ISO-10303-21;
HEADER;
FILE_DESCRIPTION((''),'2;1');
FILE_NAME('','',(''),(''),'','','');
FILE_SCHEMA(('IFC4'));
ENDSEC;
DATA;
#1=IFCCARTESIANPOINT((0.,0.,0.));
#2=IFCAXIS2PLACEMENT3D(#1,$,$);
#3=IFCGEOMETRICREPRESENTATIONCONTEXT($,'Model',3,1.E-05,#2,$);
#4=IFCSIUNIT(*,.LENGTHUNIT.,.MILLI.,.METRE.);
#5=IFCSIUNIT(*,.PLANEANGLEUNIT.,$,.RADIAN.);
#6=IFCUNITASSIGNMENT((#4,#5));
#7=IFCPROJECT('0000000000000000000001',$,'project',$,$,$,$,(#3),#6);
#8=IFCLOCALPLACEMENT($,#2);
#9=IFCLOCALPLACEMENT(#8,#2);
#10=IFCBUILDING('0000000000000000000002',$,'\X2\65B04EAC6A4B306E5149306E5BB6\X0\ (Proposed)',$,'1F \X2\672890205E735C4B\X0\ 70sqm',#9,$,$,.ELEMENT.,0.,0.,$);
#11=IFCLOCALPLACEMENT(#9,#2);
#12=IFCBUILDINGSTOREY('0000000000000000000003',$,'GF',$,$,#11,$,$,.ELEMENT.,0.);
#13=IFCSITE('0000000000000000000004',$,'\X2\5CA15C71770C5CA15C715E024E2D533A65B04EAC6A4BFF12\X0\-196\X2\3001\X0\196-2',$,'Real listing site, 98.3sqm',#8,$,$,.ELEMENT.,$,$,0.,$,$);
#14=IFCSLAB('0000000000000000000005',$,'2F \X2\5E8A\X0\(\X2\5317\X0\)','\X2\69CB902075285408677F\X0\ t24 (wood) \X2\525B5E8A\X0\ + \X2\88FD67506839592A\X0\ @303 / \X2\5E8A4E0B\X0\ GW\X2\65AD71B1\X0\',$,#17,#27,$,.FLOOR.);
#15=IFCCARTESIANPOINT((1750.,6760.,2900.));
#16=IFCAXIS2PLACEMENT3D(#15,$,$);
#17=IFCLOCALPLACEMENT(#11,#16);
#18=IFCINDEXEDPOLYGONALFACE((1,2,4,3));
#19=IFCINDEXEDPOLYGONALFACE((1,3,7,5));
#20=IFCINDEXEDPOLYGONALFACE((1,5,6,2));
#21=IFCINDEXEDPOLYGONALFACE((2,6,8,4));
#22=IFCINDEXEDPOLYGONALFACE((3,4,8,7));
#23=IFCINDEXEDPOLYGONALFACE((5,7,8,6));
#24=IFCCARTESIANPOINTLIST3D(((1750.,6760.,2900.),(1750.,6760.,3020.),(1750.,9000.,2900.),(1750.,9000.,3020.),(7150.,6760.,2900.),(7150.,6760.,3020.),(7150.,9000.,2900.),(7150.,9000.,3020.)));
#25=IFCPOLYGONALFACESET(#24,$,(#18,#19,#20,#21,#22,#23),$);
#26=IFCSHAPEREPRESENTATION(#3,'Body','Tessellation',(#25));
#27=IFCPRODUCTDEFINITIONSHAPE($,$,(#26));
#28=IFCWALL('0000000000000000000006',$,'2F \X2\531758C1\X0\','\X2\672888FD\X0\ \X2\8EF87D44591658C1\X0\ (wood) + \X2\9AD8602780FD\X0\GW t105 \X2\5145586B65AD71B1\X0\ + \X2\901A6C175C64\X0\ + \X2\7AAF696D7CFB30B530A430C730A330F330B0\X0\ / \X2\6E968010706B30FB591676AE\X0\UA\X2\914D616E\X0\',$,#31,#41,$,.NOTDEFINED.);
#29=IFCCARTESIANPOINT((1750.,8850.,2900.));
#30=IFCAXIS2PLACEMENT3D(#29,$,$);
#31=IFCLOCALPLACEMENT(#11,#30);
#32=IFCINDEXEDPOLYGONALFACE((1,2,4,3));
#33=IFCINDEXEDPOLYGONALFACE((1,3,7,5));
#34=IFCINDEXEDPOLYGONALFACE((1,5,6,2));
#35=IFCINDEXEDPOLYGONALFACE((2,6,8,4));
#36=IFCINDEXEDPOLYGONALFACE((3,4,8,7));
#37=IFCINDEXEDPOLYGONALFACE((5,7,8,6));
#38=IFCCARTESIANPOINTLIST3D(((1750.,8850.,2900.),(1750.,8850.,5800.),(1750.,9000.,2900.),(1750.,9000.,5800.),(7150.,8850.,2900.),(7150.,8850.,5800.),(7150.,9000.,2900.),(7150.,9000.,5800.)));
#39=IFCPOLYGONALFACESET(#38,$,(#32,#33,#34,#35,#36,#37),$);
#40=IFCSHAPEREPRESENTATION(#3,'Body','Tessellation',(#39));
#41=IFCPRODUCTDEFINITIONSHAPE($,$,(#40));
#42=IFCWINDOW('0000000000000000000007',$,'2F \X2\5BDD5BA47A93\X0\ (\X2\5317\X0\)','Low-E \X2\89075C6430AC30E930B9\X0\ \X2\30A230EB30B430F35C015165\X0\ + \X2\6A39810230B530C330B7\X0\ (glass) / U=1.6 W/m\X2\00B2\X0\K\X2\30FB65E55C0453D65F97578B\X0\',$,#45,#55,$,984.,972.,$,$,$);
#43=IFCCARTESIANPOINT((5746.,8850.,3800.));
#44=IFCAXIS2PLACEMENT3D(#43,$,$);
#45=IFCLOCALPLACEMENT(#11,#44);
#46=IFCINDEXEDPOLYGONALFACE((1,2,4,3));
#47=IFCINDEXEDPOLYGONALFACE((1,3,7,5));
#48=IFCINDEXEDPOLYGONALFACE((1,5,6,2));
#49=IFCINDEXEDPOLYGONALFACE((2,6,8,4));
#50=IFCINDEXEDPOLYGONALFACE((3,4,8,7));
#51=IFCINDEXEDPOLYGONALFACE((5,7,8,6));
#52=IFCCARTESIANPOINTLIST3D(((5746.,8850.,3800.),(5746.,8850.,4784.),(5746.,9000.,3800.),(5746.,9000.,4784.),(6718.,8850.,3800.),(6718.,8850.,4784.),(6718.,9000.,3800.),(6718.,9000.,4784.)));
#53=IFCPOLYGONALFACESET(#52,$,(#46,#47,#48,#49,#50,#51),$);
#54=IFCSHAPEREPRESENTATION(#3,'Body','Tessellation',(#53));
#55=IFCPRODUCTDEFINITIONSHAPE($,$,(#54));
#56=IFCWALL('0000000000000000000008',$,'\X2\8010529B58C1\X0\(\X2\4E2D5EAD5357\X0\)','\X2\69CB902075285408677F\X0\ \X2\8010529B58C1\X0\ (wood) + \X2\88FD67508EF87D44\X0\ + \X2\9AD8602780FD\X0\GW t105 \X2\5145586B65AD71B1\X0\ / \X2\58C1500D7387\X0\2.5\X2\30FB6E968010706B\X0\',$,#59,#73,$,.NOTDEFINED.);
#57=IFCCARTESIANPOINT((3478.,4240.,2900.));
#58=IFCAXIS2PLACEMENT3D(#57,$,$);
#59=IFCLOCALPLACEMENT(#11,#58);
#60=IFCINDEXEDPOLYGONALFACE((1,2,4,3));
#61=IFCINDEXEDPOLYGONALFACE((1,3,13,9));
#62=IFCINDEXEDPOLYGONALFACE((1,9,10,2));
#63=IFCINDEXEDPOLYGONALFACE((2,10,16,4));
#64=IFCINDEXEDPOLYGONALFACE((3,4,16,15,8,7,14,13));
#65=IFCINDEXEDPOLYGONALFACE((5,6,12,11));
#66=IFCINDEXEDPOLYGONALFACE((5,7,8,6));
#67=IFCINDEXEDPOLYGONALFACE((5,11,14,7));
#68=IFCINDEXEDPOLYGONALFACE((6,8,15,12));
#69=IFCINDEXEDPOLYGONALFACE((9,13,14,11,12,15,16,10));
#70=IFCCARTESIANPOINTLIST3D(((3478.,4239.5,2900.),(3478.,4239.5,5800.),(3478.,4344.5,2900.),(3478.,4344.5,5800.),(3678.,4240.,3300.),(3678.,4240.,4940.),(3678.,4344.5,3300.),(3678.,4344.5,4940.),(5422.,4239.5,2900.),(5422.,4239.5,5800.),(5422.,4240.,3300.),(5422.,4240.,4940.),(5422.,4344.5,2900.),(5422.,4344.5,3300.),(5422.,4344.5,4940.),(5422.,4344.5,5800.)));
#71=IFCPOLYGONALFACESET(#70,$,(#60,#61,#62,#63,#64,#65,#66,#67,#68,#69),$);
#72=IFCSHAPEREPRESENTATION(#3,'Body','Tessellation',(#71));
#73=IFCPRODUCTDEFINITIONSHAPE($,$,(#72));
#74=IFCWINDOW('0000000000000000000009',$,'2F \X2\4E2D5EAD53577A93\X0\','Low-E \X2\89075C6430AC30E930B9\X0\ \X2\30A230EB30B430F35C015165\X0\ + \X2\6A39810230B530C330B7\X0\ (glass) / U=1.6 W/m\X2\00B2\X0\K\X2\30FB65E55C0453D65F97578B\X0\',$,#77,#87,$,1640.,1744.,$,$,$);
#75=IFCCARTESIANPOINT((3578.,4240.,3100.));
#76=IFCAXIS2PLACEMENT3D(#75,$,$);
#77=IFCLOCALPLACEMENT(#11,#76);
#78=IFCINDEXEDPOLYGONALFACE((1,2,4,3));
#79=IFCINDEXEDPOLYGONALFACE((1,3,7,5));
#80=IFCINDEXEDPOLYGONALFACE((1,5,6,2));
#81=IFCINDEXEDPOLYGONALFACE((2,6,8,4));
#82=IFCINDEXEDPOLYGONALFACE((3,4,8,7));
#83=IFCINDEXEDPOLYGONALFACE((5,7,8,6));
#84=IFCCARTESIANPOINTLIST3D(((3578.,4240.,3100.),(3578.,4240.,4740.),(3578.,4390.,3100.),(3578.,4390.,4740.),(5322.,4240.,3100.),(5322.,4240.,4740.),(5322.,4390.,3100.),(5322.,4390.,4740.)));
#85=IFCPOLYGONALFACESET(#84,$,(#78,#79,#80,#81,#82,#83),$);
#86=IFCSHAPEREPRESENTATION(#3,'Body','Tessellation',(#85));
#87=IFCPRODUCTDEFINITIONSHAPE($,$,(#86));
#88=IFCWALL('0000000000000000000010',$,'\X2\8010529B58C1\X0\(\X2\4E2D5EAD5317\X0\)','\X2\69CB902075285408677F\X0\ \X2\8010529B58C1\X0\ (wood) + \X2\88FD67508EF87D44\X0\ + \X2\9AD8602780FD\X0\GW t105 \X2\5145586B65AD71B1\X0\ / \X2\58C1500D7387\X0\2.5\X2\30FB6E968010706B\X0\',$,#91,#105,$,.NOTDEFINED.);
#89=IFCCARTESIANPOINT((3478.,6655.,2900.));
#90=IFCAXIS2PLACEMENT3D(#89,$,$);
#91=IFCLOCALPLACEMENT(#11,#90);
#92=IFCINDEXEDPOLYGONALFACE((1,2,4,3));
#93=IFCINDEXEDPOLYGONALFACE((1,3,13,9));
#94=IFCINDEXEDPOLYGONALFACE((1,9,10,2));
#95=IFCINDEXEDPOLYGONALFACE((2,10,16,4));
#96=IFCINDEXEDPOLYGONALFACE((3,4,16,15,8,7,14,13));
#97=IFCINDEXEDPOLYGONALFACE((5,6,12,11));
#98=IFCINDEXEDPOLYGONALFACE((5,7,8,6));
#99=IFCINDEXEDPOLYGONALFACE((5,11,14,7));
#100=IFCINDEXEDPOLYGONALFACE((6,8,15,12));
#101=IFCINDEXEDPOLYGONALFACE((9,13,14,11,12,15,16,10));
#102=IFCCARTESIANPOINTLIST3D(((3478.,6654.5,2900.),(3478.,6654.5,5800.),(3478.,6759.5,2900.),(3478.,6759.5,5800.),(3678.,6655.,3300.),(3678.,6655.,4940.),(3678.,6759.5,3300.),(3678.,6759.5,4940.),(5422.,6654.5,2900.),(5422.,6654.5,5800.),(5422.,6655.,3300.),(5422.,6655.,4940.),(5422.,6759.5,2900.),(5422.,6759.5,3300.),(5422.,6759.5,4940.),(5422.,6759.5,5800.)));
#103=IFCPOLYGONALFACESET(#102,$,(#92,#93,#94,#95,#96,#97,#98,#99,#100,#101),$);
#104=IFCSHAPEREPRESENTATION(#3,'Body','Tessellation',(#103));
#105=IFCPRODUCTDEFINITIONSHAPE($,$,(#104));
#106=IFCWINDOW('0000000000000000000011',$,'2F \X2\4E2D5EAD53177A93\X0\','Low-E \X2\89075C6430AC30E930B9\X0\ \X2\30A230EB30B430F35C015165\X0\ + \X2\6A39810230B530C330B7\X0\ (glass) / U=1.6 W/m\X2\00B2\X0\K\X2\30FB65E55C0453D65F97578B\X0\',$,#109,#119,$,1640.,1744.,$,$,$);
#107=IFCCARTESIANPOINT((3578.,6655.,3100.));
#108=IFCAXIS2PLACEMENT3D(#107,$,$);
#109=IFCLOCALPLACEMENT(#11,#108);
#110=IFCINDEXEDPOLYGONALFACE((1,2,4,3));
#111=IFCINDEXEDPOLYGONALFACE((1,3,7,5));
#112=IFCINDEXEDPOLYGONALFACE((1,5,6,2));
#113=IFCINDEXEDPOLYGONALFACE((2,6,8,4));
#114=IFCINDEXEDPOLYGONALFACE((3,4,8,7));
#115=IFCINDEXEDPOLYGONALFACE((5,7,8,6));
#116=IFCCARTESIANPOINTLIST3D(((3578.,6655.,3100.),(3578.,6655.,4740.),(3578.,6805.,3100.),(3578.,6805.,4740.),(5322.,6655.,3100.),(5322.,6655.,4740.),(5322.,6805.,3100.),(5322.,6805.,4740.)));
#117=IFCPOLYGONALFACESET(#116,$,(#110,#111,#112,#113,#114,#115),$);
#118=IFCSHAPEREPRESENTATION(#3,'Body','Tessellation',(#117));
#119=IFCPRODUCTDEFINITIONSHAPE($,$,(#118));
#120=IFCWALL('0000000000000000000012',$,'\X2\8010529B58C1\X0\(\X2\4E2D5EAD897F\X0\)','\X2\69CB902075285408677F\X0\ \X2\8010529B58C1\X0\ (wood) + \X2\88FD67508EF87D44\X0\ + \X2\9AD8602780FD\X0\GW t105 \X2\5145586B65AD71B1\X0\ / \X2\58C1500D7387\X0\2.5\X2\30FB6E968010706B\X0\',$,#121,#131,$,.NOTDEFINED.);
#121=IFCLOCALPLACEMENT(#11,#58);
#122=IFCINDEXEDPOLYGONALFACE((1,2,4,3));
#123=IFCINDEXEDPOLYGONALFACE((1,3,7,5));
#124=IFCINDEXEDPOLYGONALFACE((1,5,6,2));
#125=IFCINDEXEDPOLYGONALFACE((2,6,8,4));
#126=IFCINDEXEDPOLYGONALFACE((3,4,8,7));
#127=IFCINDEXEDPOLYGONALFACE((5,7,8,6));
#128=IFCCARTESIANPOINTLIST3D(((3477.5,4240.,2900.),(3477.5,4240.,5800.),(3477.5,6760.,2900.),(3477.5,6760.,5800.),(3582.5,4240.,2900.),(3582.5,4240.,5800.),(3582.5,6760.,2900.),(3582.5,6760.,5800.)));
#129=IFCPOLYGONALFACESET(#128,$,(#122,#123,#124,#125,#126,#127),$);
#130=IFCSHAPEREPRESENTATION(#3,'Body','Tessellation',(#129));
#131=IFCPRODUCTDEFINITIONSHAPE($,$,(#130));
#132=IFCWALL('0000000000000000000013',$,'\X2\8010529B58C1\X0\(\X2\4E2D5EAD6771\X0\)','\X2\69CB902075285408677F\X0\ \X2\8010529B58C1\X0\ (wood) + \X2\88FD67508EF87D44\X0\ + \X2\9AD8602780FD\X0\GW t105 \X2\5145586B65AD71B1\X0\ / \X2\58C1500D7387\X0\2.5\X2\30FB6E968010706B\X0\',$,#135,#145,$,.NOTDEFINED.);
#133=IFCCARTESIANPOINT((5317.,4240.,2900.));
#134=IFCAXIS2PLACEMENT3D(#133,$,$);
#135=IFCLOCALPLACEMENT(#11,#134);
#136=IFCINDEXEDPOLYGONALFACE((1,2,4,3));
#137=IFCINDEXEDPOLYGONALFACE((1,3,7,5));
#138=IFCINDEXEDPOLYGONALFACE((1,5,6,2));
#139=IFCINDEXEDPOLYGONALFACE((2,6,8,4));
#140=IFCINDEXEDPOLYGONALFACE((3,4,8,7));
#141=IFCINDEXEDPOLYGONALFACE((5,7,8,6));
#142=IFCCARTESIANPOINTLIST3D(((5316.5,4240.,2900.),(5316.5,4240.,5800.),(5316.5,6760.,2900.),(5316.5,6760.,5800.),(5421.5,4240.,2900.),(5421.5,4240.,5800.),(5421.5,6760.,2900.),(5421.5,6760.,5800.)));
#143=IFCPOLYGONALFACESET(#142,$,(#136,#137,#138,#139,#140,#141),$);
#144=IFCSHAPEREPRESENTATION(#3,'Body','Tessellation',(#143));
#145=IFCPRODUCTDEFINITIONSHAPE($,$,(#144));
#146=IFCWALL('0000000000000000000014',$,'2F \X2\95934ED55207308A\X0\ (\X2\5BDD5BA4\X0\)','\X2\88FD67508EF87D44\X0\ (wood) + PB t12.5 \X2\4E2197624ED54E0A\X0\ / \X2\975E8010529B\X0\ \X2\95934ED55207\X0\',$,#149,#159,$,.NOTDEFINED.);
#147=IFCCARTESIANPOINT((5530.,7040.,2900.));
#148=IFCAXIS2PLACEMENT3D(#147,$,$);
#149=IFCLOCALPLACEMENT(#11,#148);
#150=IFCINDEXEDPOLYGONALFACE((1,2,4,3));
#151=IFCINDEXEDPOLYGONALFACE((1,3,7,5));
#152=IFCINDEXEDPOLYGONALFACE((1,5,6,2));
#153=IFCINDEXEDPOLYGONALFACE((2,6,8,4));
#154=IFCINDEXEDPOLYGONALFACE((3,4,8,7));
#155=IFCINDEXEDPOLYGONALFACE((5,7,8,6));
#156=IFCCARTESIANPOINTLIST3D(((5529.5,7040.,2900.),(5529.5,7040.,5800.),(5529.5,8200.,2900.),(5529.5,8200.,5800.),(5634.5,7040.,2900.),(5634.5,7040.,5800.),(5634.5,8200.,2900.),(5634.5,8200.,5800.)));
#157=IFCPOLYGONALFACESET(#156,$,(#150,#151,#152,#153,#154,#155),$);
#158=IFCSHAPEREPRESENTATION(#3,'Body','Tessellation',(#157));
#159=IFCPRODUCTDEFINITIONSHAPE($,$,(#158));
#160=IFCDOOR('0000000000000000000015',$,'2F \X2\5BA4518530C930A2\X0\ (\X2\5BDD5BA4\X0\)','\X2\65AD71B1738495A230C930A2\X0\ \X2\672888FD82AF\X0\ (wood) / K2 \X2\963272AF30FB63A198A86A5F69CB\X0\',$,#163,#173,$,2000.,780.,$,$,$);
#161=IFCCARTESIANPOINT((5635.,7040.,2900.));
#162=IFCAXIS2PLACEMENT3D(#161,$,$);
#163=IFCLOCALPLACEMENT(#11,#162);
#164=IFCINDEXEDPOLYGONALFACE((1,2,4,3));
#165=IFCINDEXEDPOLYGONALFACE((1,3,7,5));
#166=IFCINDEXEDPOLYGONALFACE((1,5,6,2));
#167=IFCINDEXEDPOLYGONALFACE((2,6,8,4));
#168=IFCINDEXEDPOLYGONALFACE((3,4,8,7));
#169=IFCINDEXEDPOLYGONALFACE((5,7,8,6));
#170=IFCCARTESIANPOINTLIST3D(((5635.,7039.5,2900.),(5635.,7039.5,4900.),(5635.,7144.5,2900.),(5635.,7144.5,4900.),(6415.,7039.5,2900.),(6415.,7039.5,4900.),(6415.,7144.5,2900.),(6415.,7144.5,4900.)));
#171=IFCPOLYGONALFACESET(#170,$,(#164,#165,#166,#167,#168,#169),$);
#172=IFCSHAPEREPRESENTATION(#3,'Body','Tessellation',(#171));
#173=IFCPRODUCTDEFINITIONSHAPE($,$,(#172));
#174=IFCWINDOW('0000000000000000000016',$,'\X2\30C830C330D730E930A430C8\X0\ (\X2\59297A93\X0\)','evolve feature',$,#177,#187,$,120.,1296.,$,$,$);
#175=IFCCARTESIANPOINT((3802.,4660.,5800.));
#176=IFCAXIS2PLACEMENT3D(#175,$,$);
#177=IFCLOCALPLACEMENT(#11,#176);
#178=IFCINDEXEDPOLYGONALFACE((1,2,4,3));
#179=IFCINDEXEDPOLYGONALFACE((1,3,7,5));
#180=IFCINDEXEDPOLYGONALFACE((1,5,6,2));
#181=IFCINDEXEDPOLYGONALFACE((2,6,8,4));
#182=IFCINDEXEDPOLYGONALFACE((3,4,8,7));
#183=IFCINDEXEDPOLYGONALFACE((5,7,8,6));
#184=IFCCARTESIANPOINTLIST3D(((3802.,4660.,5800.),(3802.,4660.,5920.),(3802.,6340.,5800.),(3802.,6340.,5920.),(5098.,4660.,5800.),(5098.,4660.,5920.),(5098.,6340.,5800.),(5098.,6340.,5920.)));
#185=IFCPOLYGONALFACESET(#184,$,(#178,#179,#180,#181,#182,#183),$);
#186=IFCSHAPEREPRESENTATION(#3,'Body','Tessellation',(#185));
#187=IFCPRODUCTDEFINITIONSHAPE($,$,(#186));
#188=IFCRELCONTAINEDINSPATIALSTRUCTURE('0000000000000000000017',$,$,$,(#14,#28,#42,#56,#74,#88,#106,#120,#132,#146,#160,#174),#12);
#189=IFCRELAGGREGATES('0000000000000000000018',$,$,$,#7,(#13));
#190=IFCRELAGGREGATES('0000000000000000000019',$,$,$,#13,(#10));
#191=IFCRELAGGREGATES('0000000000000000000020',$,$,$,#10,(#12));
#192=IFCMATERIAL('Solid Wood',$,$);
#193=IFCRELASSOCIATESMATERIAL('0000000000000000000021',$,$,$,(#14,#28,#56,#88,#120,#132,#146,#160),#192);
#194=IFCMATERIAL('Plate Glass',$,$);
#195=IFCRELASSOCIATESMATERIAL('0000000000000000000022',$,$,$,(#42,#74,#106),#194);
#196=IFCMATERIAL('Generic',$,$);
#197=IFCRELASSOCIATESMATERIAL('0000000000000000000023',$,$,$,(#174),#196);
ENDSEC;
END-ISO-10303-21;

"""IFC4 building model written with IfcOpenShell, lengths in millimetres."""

from ifc_helpers import new_model, si_unit, frame, frame_2d, origin, place, context, project, spatial, rectangle, extrude, material, element, fill, save


model = new_model("IFC4")

# Units and contexts
model_context = context("Model", 3, precision=1e-05, world=origin())
ifc_project = project(units=[si_unit("LENGTHUNIT", "METRE", prefix="MILLI"), si_unit("PLANEANGLEUNIT", "RADIAN")], contexts=[model_context])

# Site, building, storey
site_placement = place(None, origin())
site = spatial("IfcSite", under=ifc_project, at=site_placement, Name="岡山県岡山市中区新京橋２-196、196-2", ObjectType="Real listing site, 98.3sqm", CompositionType="ELEMENT", RefElevation=0.0)
building_placement = place(site_placement, origin())
building = spatial("IfcBuilding", under=site, at=building_placement, Name="新京橋の光の家 (Proposed)", ObjectType="1F 木造平屋 70sqm", CompositionType="ELEMENT", ElevationOfRefHeight=0.0, ElevationOfTerrain=0.0)
storey_placement = place(building_placement, origin())
storey = spatial("IfcBuildingStorey", under=building, at=storey_placement, Name="GF", CompositionType="ELEMENT", Elevation=0.0)

# Slab
ifc_material_1 = material(Name="Solid Wood")
slab_placement = place(storey_placement, frame((1750.0, 6760.0, 2900.0)))
element("IfcSlab", 1, at=slab_placement, inside=storey, material=ifc_material_1, Name="2F 床(北)", Description="構造用合板 t24 (wood) 剛床 + 製材根太 @303 / 床下 GW断熱", PredefinedType="FLOOR", context=model_context, shape_type="SweptSolid", body=[
    extrude(rectangle(XDim=5400.0, YDim=2240.0, at=frame_2d((2700.0, 1120.0))), frame((1750.0, 6760.0, 2900.0)), (0.0, 0.0, 1.0), 120.0),
])

# Walls, openings, windows
wall_1_placement = place(storey_placement, frame((1750.0, 8850.0, 2900.0)))
wall_1 = element("IfcWall", 2, at=wall_1_placement, inside=storey, material=ifc_material_1, Name="2F 北壁", Description="木製 軸組外壁 (wood) + 高性能GW t105 充填断熱 + 通気層 + 窯業系サイディング / 準耐火・外皮UA配慮", PredefinedType="NOTDEFINED", context=model_context, shape_type="SweptSolid", body=[
    extrude(rectangle(XDim=5400.0, YDim=150.0, at=frame_2d((2700.0, 75.0))), frame((1750.0, 8850.0, 2900.0)), (0.0, 0.0, 1.0), 2900.0),
])
opening_1_placement = place(storey_placement, frame((5746.0, 8850.0, 3800.0)))
opening_1 = element("IfcOpeningElement", 3, at=opening_1_placement, cuts=wall_1, PredefinedType="NOTDEFINED", context=model_context, shape_type="SweptSolid", body=[
    extrude(rectangle(XDim=972.0, YDim=150.0, at=frame_2d((486.0, 75.0))), frame((5746.0, 8850.0, 3800.0)), (0.0, 0.0, 1.0), 984.0),
])
ifc_material_2 = material(Name="Plate Glass")
window_1_placement = place(storey_placement, frame((5746.0, 8850.0, 3800.0)))
window_1 = element("IfcWindow", 4, at=window_1_placement, inside=storey, material=ifc_material_2, Name="2F 寝室窓 (北)", Description="Low-E 複層ガラス アルゴン封入 + 樹脂サッシ (glass) / U=1.6 W/m²K・日射取得型", OverallHeight=984.0, OverallWidth=972.0, context=model_context, shape_type="SweptSolid", body=[
    extrude(rectangle(XDim=972.0, YDim=150.0, at=frame_2d((486.0, 75.0))), frame((5746.0, 8850.0, 3800.0)), (0.0, 0.0, 1.0), 984.0),
])
fill(opening_1, window_1)
wall_2_placement = place(storey_placement, frame((3478.0, 4240.0, 2900.0)))
wall_2 = element("IfcWall", 5, at=wall_2_placement, inside=storey, material=ifc_material_1, Name="耐力壁(中庭南)", Description="構造用合板 耐力壁 (wood) + 製材軸組 + 高性能GW t105 充填断熱 / 壁倍率2.5・準耐火", PredefinedType="NOTDEFINED", context=model_context, shape_type="SweptSolid", body=[
    extrude(rectangle(XDim=1944.0, YDim=105.0, at=frame_2d((972.0, 52.0))), frame((3478.0, 4240.0, 2900.0)), (0.0, 0.0, 1.0), 2900.0),
])
opening_2_placement = place(storey_placement, frame((3578.0, 4240.0, 3100.0)))
opening_2 = element("IfcOpeningElement", 6, at=opening_2_placement, cuts=wall_2, PredefinedType="NOTDEFINED", context=model_context, shape_type="SweptSolid", body=[
    extrude(rectangle(XDim=1744.0, YDim=150.0, at=frame_2d((872.0, 75.0))), frame((3578.0, 4240.0, 3100.0)), (0.0, 0.0, 1.0), 1640.0),
])
window_2_placement = place(storey_placement, frame((3578.0, 4240.0, 3100.0)))
window_2 = element("IfcWindow", 7, at=window_2_placement, inside=storey, material=ifc_material_2, Name="2F 中庭南窓", Description="Low-E 複層ガラス アルゴン封入 + 樹脂サッシ (glass) / U=1.6 W/m²K・日射取得型", OverallHeight=1640.0, OverallWidth=1744.0, context=model_context, shape_type="SweptSolid", body=[
    extrude(rectangle(XDim=1744.0, YDim=150.0, at=frame_2d((872.0, 75.0))), frame((3578.0, 4240.0, 3100.0)), (0.0, 0.0, 1.0), 1640.0),
])
fill(opening_2, window_2)
wall_3_placement = place(storey_placement, frame((3478.0, 6655.0, 2900.0)))
wall_3 = element("IfcWall", 8, at=wall_3_placement, inside=storey, material=ifc_material_1, Name="耐力壁(中庭北)", Description="構造用合板 耐力壁 (wood) + 製材軸組 + 高性能GW t105 充填断熱 / 壁倍率2.5・準耐火", PredefinedType="NOTDEFINED", context=model_context, shape_type="SweptSolid", body=[
    extrude(rectangle(XDim=1944.0, YDim=105.0, at=frame_2d((972.0, 52.0))), frame((3478.0, 6655.0, 2900.0)), (0.0, 0.0, 1.0), 2900.0),
])
opening_3_placement = place(storey_placement, frame((3578.0, 6655.0, 3100.0)))
opening_3 = element("IfcOpeningElement", 9, at=opening_3_placement, cuts=wall_3, PredefinedType="NOTDEFINED", context=model_context, shape_type="SweptSolid", body=[
    extrude(rectangle(XDim=1744.0, YDim=150.0, at=frame_2d((872.0, 75.0))), frame((3578.0, 6655.0, 3100.0)), (0.0, 0.0, 1.0), 1640.0),
])
window_3_placement = place(storey_placement, frame((3578.0, 6655.0, 3100.0)))
window_3 = element("IfcWindow", 10, at=window_3_placement, inside=storey, material=ifc_material_2, Name="2F 中庭北窓", Description="Low-E 複層ガラス アルゴン封入 + 樹脂サッシ (glass) / U=1.6 W/m²K・日射取得型", OverallHeight=1640.0, OverallWidth=1744.0, context=model_context, shape_type="SweptSolid", body=[
    extrude(rectangle(XDim=1744.0, YDim=150.0, at=frame_2d((872.0, 75.0))), frame((3578.0, 6655.0, 3100.0)), (0.0, 0.0, 1.0), 1640.0),
])
fill(opening_3, window_3)

# Walls
wall_4_placement = place(storey_placement, frame((3478.0, 4240.0, 2900.0)))
element("IfcWall", 11, at=wall_4_placement, inside=storey, material=ifc_material_1, Name="耐力壁(中庭西)", Description="構造用合板 耐力壁 (wood) + 製材軸組 + 高性能GW t105 充填断熱 / 壁倍率2.5・準耐火", PredefinedType="NOTDEFINED", context=model_context, shape_type="SweptSolid", body=[
    extrude(rectangle(XDim=105.0, YDim=2520.0, at=frame_2d((52.0, 1260.0))), frame((3478.0, 4240.0, 2900.0)), (0.0, 0.0, 1.0), 2900.0),
])
wall_5_placement = place(storey_placement, frame((5317.0, 4240.0, 2900.0)))
element("IfcWall", 12, at=wall_5_placement, inside=storey, material=ifc_material_1, Name="耐力壁(中庭東)", Description="構造用合板 耐力壁 (wood) + 製材軸組 + 高性能GW t105 充填断熱 / 壁倍率2.5・準耐火", PredefinedType="NOTDEFINED", context=model_context, shape_type="SweptSolid", body=[
    extrude(rectangle(XDim=105.0, YDim=2520.0, at=frame_2d((52.0, 1260.0))), frame((5317.0, 4240.0, 2900.0)), (0.0, 0.0, 1.0), 2900.0),
])
wall_6_placement = place(storey_placement, frame((5530.0, 7040.0, 2900.0)))
element("IfcWall", 13, at=wall_6_placement, inside=storey, material=ifc_material_1, Name="2F 間仕切り (寝室)", Description="製材軸組 (wood) + PB t12.5 両面仕上 / 非耐力 間仕切", PredefinedType="NOTDEFINED", context=model_context, shape_type="SweptSolid", body=[
    extrude(rectangle(XDim=105.0, YDim=1160.0, at=frame_2d((52.0, 580.0))), frame((5530.0, 7040.0, 2900.0)), (0.0, 0.0, 1.0), 2900.0),
])

# Door
door_placement = place(storey_placement, frame((5635.0, 7040.0, 2900.0)))
element("IfcDoor", 14, at=door_placement, inside=storey, material=ifc_material_1, Name="2F 室内ドア (寝室)", Description="断熱玄関ドア 木製芯 (wood) / K2 防犯・採風機構", OverallHeight=2000.0, OverallWidth=780.0, context=model_context, shape_type="SweptSolid", body=[
    extrude(rectangle(XDim=780.0, YDim=105.0, at=frame_2d((390.0, 52.0))), frame((5635.0, 7040.0, 2900.0)), (0.0, 0.0, 1.0), 2000.0),
])

# Window
ifc_material_3 = material(Name="Generic")
window_4_placement = place(storey_placement, frame((3802.0, 4660.0, 5800.0)))
element("IfcWindow", 15, at=window_4_placement, inside=storey, material=ifc_material_3, Name="トップライト (天窓)", Description="evolve feature", OverallHeight=120.0, OverallWidth=1296.0, context=model_context, shape_type="SweptSolid", body=[
    extrude(rectangle(XDim=1296.0, YDim=1680.0, at=frame_2d((648.0, 840.0))), frame((3802.0, 4660.0, 5800.0)), (0.0, 0.0, 1.0), 120.0),
])

save(model, "model.ifc")
